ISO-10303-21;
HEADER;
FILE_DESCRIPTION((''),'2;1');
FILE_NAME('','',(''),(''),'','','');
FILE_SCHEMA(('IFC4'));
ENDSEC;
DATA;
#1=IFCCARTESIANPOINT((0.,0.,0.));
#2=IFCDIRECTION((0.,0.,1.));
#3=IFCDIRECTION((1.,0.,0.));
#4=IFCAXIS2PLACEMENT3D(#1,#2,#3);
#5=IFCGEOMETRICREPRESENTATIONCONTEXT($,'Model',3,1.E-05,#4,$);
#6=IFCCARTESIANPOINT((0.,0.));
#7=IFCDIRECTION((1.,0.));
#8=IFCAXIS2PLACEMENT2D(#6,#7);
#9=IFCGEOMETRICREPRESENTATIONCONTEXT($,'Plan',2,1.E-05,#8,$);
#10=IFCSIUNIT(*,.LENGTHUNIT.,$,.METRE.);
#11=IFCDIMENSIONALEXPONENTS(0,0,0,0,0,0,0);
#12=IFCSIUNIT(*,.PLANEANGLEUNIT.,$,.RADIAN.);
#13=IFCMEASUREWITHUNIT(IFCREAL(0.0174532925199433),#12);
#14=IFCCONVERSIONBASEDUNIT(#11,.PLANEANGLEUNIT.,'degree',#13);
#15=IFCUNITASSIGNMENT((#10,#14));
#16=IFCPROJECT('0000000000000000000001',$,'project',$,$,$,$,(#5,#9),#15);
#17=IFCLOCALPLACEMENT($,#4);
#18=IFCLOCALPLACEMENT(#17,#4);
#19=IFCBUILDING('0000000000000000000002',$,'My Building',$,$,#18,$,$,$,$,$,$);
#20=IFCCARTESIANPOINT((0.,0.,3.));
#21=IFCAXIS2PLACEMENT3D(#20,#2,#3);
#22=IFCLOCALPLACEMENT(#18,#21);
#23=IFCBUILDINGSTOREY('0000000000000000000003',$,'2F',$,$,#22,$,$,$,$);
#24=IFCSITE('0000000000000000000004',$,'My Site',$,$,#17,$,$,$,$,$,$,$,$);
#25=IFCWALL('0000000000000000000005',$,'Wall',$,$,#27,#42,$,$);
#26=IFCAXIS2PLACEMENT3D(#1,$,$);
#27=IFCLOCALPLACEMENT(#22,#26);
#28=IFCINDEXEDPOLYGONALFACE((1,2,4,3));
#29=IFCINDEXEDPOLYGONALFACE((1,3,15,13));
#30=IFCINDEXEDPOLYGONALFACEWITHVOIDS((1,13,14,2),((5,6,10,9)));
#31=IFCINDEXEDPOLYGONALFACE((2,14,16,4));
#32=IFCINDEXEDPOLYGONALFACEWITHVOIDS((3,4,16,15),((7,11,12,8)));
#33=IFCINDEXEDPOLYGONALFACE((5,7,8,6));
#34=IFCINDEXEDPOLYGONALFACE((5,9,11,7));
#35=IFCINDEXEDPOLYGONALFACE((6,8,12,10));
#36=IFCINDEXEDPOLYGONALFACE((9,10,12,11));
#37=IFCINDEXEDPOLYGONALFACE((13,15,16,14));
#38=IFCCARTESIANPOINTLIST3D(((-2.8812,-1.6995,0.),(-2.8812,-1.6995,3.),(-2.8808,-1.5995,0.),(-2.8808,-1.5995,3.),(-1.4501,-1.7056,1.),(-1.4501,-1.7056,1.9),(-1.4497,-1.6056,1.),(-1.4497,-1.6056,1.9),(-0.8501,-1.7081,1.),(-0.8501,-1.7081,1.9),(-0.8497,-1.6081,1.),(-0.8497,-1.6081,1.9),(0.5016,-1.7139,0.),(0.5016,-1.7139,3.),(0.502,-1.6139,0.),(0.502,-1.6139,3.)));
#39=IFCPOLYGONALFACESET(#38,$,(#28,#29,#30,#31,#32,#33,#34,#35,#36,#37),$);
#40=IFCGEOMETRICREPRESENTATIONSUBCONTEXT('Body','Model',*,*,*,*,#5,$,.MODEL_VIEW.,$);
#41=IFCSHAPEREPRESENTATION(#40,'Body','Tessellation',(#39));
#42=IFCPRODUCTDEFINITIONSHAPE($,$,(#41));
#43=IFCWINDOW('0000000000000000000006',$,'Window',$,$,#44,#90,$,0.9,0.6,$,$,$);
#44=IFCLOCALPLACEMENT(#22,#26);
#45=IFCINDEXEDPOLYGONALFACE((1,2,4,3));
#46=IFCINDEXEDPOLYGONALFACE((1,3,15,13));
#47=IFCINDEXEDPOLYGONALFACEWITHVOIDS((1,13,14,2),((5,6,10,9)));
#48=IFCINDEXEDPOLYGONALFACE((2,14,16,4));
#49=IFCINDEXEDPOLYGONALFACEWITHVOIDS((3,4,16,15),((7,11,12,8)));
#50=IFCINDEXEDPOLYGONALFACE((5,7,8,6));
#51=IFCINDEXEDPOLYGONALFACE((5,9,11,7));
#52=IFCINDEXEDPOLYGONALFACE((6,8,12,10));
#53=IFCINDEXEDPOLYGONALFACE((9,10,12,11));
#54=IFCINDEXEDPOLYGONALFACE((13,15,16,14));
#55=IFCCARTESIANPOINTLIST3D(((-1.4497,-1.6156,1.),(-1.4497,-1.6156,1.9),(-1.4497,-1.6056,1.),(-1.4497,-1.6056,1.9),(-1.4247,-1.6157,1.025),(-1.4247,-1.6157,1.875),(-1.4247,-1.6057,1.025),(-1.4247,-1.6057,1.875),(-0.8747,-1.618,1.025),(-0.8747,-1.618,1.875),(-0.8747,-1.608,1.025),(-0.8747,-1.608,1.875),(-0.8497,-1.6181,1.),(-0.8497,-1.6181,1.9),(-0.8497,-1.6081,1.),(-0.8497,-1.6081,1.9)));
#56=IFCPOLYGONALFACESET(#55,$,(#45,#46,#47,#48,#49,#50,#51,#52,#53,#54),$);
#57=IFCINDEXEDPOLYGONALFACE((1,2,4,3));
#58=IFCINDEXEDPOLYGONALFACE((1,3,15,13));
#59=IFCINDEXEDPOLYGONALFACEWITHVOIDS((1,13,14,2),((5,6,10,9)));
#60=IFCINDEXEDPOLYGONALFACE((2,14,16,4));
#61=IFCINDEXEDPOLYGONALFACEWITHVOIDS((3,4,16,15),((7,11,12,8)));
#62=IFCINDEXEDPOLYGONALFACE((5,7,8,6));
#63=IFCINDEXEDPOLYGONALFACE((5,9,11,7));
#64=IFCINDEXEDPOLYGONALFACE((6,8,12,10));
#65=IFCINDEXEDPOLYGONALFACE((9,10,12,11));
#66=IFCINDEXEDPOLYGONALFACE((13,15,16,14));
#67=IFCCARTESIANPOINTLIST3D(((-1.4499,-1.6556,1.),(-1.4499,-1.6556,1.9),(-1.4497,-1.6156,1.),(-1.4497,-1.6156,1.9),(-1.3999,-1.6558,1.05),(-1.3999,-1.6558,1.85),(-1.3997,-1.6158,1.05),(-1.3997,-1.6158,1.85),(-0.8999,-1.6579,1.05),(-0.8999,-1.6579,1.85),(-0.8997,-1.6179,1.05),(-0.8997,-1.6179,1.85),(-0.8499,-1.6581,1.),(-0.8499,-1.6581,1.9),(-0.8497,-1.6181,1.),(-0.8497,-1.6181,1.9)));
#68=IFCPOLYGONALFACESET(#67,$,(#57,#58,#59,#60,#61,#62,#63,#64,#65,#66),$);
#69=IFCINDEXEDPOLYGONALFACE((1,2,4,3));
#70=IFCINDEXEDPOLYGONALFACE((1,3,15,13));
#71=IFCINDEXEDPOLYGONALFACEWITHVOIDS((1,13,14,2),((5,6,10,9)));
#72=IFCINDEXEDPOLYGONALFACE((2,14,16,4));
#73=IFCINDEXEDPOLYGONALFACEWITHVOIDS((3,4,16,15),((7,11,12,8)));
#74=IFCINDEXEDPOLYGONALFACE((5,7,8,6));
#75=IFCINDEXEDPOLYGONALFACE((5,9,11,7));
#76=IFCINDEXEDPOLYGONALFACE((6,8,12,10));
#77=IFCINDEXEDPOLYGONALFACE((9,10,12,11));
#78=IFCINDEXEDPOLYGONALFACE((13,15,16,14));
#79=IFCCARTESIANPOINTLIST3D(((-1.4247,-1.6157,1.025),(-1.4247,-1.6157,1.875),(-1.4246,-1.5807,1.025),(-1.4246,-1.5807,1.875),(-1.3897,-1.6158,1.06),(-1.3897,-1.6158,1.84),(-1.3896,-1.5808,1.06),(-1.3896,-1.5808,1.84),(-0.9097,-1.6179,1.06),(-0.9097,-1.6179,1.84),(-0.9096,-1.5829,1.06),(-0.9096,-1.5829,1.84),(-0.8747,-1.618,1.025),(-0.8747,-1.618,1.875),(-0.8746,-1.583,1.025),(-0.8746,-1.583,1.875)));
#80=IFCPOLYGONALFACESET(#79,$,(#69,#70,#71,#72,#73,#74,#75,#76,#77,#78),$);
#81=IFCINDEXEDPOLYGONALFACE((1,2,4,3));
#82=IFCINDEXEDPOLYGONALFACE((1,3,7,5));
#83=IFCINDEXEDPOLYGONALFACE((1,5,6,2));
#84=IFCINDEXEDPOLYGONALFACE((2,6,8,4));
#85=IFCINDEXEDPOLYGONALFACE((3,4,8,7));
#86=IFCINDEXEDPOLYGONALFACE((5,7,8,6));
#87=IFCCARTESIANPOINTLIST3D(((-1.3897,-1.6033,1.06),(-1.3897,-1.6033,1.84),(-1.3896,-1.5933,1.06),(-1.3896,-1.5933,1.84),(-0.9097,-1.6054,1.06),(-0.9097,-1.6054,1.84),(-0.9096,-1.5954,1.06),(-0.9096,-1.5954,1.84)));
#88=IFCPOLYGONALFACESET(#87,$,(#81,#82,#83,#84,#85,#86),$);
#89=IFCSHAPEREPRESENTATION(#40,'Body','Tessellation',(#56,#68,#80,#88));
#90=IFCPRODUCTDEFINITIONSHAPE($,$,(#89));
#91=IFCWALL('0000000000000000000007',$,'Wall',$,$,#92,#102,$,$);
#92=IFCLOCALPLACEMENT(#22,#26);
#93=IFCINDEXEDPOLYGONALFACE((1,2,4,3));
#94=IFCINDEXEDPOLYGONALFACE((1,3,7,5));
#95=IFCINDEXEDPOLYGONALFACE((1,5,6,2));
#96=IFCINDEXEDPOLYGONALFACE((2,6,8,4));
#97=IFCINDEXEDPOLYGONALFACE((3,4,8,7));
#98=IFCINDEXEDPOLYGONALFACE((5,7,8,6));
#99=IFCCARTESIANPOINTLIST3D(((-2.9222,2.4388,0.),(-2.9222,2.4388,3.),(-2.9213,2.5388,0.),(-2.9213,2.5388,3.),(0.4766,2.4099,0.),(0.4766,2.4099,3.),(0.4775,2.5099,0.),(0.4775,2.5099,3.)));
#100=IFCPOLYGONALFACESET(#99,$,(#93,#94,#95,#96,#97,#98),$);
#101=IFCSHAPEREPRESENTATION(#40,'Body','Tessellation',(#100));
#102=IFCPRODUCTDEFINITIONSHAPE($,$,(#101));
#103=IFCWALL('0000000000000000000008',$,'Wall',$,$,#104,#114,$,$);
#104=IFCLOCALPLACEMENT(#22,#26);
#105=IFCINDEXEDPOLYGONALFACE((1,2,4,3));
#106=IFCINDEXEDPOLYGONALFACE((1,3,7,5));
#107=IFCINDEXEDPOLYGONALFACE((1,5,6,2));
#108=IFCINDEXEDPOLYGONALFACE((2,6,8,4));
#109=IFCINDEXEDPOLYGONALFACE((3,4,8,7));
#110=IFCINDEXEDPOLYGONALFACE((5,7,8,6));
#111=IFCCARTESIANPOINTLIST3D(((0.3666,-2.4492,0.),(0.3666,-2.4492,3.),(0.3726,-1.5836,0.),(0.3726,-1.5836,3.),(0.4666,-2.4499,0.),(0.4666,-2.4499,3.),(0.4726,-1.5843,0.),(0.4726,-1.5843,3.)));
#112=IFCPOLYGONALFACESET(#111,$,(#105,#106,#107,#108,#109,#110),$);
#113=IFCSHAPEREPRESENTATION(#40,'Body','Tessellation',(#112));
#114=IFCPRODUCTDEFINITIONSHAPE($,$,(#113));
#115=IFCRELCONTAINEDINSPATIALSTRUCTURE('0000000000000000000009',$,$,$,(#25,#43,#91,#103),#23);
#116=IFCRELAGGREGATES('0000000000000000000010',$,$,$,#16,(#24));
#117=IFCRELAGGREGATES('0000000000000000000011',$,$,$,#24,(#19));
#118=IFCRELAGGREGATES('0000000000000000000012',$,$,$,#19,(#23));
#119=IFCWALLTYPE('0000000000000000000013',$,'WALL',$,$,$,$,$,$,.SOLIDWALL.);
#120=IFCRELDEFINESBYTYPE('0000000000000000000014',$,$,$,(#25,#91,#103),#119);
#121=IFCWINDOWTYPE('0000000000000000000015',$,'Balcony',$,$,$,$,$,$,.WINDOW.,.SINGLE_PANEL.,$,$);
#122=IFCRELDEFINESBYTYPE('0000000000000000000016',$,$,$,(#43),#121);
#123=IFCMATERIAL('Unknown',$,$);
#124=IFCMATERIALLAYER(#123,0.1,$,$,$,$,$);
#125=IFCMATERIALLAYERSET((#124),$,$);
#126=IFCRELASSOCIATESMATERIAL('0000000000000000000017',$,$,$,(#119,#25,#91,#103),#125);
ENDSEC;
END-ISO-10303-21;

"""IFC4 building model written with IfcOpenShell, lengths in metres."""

from ifc_helpers import new_model, entity, si_unit, converted_unit, frame, origin_with_axes, origin_2d_with_axis, place, context, subcontext, project, spatial, line, indexed_curve, outline, extrude, shape, source, transform, mapped, material, layer, layer_set, layer_usage, type_object, type_shapes, element, fill, save


model = new_model("IFC4")

# Units and contexts
model_context = context("Model", 3, precision=1e-05, world=origin_with_axes())
plan_context = context("Plan", 2, precision=1e-05, world=origin_2d_with_axis())
body_context_1 = subcontext(model_context, "Body", "Model", "MODEL_VIEW")
body_context_2 = subcontext(plan_context, "Body", "Plan", "PLAN_VIEW")
ifc_project = project(units=[si_unit("LENGTHUNIT", "METRE"), converted_unit("PLANEANGLEUNIT", "degree", entity("IfcReal", 0.0174532925199433), si_unit("PLANEANGLEUNIT", "RADIAN"), dimensions=[0, 0, 0, 0, 0, 0, 0])], contexts=[model_context, plan_context])

# Site, building, storey
site_placement = place(None, origin_with_axes())
site = spatial("IfcSite", under=ifc_project, at=site_placement, Name="My Site")
building_placement = place(site_placement, origin_with_axes())
building = spatial("IfcBuilding", under=site, at=building_placement, Name="My Building")
storey_placement = place(building_placement, frame((0.0, 0.0, 3.0), z_axis=(0.0, 0.0, 1.0), x_axis=(1.0, 0.0, 0.0)))
storey = spatial("IfcBuildingStorey", under=building, at=storey_placement, Name="2F")

# Shared definitions
ifc_material = material(Name="Unknown")

# Shared definitions
ifc_layer_1 = layer(ifc_material, 0.1)
ifc_layer_set_1 = layer_set([ifc_layer_1])
wall_type = type_object("IfcWallType", Name="WALL", PredefinedType="SOLIDWALL", material=ifc_layer_set_1)

# Wall, opening, window
ifc_layer_usage_1 = layer_usage(ifc_layer_set_1, "AXIS2", "POSITIVE", 0.0)
wall_1_placement = place(storey_placement, frame((-2.8812, -1.6995, 0.0), z_axis=(0.0, 0.0, 1.0), x_axis=(0.999991, -0.004277, 0.0)))
wall_1 = element("IfcWall", 1, at=wall_1_placement, inside=storey, type_object=wall_type, material=ifc_layer_usage_1, Name="Wall", context=body_context_1, shape_type="SweptSolid", body=[
    extrude(outline(indexed_curve([(0.0, 0.0), (0.0, 0.1), (3.3828, 0.1), (3.3828, 0.0)], segments=[line(1, 2, 3, 4, 1)])), origin_with_axes(), (0.0, 0.0, 1.0), 3.0),
])
shared_shape_1 = source(origin_with_axes(), body_context_1, "Body", "SweptSolid", [
    extrude(outline(indexed_curve([(0.0, 0.0), (0.6, 0.0), (0.6, 0.9), (0.0, 0.9)], segments=[line(1, 2, 3, 4, 1)])), frame((0.0, -0.6, 0.0), z_axis=(0.0, -1.0, 0.0), x_axis=(1.0, 0.0, 0.0)), (0.0, 0.0, -1.0), 1.2),
])
opening_1_placement = place(wall_1_placement, frame((1.4311, 0.0, 1.0), z_axis=(0.0, 0.0, 1.0), x_axis=(1.0, 0.0, 0.0)))
opening_1 = element("IfcOpeningElement", 2, at=opening_1_placement, cuts=wall_1, PredefinedType="OPENING", context=body_context_1, shape_type="MappedRepresentation", body=[
    mapped(shared_shape_1, transform((0.0, 0.0, 0.0), x_axis=(1.0, 0.0, 0.0), y_axis=(0.0, 1.0, 0.0), z_axis=(0.0, 0.0, 1.0), scale=1.0)),
])
window_type_1 = type_object("IfcWindowType", Name="Balcony", PartitioningType="SINGLE_PANEL", PredefinedType="WINDOW")
shared_shape_2 = source(origin_with_axes(), body_context_1, "Body", "SweptSolid", [
    extrude(outline(indexed_curve([(0.0, 0.0), (0.6, 0.0), (0.6, 0.9), (0.0, 0.9)], segments=[line(1, 2, 3, 4, 1)]), holes=[indexed_curve([(0.025, 0.025), (0.575, 0.025), (0.575, 0.875), (0.025, 0.875)], segments=[line(1, 2, 3, 4, 1)])]), frame((0.0, 0.09, 0.0), z_axis=(0.0, -1.0, 0.0), x_axis=(1.0, 0.0, 0.0)), (0.0, 0.0, -1.0), 0.01),
    extrude(outline(indexed_curve([(0.0, 0.0), (0.6, 0.0), (0.6, 0.9), (0.0, 0.9)], segments=[line(1, 2, 3, 4, 1)]), holes=[indexed_curve([(0.05, 0.05), (0.55, 0.05), (0.55, 0.85), (0.05, 0.85)], segments=[line(1, 2, 3, 4, 1)])]), frame((0.0, 0.05, 0.0), z_axis=(0.0, -1.0, 0.0), x_axis=(1.0, 0.0, 0.0)), (0.0, 0.0, -1.0), 0.04),
    extrude(outline(indexed_curve([(0.0, 0.0), (0.55, 0.0), (0.55, 0.85), (0.0, 0.85)], segments=[line(1, 2, 3, 4, 1)]), holes=[indexed_curve([(0.035, 0.035), (0.515, 0.035), (0.515, 0.815), (0.035, 0.815)], segments=[line(1, 2, 3, 4, 1)])]), frame((0.025, 0.09, 0.025), z_axis=(0.0, -1.0, 0.0), x_axis=(1.0, 0.0, 0.0)), (0.0, 0.0, -1.0), 0.035),
    extrude(outline(indexed_curve([(0.035, 0.035), (0.515, 0.035), (0.515, 0.815), (0.035, 0.815)], segments=[line(1, 2, 3, 4, 1)])), frame((0.025, 0.1025, 0.025), z_axis=(0.0, -1.0, 0.0), x_axis=(1.0, 0.0, 0.0)), (0.0, 0.0, -1.0), 0.01),
])
shared_shape_3 = source(origin_with_axes(), body_context_2, "Body", "Curve2D", [
    entity("IfcIndexedPolyCurve", entity("IfcCartesianPointList2D", [[0.05, 0.05], [0.55, 0.05]])),
    entity("IfcIndexedPolyCurve", entity("IfcCartesianPointList2D", [[0.0, 0.1], [0.025, 0.1], [0.025, 0.09], [0.05, 0.09], [0.05, 0.05], [0.0, 0.05]]), [entity("IfcLineIndex", [1, 2, 3, 4, 5, 6, 1])]),
    entity("IfcIndexedPolyCurve", entity("IfcCartesianPointList2D", [[0.6, 0.1], [0.575, 0.1], [0.575, 0.09], [0.55, 0.09], [0.55, 0.05], [0.6, 0.05]]), [entity("IfcLineIndex", [1, 2, 3, 4, 5, 6, 1])]),
    entity("IfcIndexedPolyCurve", entity("IfcCartesianPointList2D", [[0.025, 0.09], [0.06, 0.09], [0.06, 0.125], [0.025, 0.125]]), [entity("IfcLineIndex", [1, 2, 3, 4, 1])]),
    entity("IfcIndexedPolyCurve", entity("IfcCartesianPointList2D", [[0.575, 0.09], [0.54, 0.09], [0.54, 0.125], [0.575, 0.125]]), [entity("IfcLineIndex", [1, 2, 3, 4, 1])]),
    entity("IfcIndexedPolyCurve", entity("IfcCartesianPointList2D", [[0.06, 0.09], [0.54, 0.09]])),
    entity("IfcIndexedPolyCurve", entity("IfcCartesianPointList2D", [[0.06, 0.125], [0.54, 0.125]])),
    entity("IfcIndexedPolyCurve", entity("IfcCartesianPointList2D", [[0.06, 0.1075], [0.54, 0.1075]])),
])
type_shapes(window_type_1, [shared_shape_2, shared_shape_3])
window_1_placement = place(opening_1_placement, frame((0.0, 0.0, 0.0), z_axis=(0.0, 0.0, 1.0), x_axis=(1.0, 0.0, 0.0)))
window_1 = element("IfcWindow", 3, at=window_1_placement, inside=storey, type_object=window_type_1, Name="Window", OverallHeight=0.9, OverallWidth=0.6, shapes=[
    shape(body_context_1, "Body", "MappedRepresentation", [mapped(shared_shape_2, transform((0.0, 0.0, 0.0), x_axis=(1.0, 0.0, 0.0), y_axis=(0.0, 1.0, 0.0), z_axis=(0.0, 0.0, 1.0), scale=1.0))]),
    shape(body_context_2, "Body", "MappedRepresentation", [mapped(shared_shape_3, transform((0.0, 0.0, 0.0), x_axis=(1.0, 0.0, 0.0), y_axis=(0.0, 1.0, 0.0), z_axis=(0.0, 0.0, 1.0), scale=1.0))]),
])
fill(opening_1, window_1)

# Wall
ifc_layer_usage_2 = layer_usage(ifc_layer_set_1, "AXIS2", "POSITIVE", 0.0)
wall_2_placement = place(storey_placement, frame((-2.9222, 2.4388, 0.0), z_axis=(0.0, 0.0, 1.0), x_axis=(0.999964, -0.008491, 0.0)))
element("IfcWall", 4, at=wall_2_placement, inside=storey, type_object=wall_type, material=ifc_layer_usage_2, Name="Wall", context=body_context_1, shape_type="SweptSolid", body=[
    extrude(outline(indexed_curve([(0.0, 0.0), (0.0, 0.1), (3.3989, 0.1), (3.3989, 0.0)], segments=[line(1, 2, 3, 4, 1)])), origin_with_axes(), (0.0, 0.0, 1.0), 3.0),
])

# Wall
ifc_layer_usage_3 = layer_usage(ifc_layer_set_1, "AXIS2", "POSITIVE", 0.0)
wall_3_placement = place(storey_placement, frame((0.3726, -1.5836, 0.0), z_axis=(0.0, 0.0, 1.0), x_axis=(-0.006993, -0.999976, 0.0)))
element("IfcWall", 5, at=wall_3_placement, inside=storey, type_object=wall_type, material=ifc_layer_usage_3, Name="Wall", context=body_context_1, shape_type="SweptSolid", body=[
    extrude(outline(indexed_curve([(0.0, 0.0), (0.0, 0.1), (0.8656, 0.1), (0.8656, 0.0)], segments=[line(1, 2, 3, 4, 1)])), origin_with_axes(), (0.0, 0.0, 1.0), 3.0),
])

save(model, "model.ifc")
